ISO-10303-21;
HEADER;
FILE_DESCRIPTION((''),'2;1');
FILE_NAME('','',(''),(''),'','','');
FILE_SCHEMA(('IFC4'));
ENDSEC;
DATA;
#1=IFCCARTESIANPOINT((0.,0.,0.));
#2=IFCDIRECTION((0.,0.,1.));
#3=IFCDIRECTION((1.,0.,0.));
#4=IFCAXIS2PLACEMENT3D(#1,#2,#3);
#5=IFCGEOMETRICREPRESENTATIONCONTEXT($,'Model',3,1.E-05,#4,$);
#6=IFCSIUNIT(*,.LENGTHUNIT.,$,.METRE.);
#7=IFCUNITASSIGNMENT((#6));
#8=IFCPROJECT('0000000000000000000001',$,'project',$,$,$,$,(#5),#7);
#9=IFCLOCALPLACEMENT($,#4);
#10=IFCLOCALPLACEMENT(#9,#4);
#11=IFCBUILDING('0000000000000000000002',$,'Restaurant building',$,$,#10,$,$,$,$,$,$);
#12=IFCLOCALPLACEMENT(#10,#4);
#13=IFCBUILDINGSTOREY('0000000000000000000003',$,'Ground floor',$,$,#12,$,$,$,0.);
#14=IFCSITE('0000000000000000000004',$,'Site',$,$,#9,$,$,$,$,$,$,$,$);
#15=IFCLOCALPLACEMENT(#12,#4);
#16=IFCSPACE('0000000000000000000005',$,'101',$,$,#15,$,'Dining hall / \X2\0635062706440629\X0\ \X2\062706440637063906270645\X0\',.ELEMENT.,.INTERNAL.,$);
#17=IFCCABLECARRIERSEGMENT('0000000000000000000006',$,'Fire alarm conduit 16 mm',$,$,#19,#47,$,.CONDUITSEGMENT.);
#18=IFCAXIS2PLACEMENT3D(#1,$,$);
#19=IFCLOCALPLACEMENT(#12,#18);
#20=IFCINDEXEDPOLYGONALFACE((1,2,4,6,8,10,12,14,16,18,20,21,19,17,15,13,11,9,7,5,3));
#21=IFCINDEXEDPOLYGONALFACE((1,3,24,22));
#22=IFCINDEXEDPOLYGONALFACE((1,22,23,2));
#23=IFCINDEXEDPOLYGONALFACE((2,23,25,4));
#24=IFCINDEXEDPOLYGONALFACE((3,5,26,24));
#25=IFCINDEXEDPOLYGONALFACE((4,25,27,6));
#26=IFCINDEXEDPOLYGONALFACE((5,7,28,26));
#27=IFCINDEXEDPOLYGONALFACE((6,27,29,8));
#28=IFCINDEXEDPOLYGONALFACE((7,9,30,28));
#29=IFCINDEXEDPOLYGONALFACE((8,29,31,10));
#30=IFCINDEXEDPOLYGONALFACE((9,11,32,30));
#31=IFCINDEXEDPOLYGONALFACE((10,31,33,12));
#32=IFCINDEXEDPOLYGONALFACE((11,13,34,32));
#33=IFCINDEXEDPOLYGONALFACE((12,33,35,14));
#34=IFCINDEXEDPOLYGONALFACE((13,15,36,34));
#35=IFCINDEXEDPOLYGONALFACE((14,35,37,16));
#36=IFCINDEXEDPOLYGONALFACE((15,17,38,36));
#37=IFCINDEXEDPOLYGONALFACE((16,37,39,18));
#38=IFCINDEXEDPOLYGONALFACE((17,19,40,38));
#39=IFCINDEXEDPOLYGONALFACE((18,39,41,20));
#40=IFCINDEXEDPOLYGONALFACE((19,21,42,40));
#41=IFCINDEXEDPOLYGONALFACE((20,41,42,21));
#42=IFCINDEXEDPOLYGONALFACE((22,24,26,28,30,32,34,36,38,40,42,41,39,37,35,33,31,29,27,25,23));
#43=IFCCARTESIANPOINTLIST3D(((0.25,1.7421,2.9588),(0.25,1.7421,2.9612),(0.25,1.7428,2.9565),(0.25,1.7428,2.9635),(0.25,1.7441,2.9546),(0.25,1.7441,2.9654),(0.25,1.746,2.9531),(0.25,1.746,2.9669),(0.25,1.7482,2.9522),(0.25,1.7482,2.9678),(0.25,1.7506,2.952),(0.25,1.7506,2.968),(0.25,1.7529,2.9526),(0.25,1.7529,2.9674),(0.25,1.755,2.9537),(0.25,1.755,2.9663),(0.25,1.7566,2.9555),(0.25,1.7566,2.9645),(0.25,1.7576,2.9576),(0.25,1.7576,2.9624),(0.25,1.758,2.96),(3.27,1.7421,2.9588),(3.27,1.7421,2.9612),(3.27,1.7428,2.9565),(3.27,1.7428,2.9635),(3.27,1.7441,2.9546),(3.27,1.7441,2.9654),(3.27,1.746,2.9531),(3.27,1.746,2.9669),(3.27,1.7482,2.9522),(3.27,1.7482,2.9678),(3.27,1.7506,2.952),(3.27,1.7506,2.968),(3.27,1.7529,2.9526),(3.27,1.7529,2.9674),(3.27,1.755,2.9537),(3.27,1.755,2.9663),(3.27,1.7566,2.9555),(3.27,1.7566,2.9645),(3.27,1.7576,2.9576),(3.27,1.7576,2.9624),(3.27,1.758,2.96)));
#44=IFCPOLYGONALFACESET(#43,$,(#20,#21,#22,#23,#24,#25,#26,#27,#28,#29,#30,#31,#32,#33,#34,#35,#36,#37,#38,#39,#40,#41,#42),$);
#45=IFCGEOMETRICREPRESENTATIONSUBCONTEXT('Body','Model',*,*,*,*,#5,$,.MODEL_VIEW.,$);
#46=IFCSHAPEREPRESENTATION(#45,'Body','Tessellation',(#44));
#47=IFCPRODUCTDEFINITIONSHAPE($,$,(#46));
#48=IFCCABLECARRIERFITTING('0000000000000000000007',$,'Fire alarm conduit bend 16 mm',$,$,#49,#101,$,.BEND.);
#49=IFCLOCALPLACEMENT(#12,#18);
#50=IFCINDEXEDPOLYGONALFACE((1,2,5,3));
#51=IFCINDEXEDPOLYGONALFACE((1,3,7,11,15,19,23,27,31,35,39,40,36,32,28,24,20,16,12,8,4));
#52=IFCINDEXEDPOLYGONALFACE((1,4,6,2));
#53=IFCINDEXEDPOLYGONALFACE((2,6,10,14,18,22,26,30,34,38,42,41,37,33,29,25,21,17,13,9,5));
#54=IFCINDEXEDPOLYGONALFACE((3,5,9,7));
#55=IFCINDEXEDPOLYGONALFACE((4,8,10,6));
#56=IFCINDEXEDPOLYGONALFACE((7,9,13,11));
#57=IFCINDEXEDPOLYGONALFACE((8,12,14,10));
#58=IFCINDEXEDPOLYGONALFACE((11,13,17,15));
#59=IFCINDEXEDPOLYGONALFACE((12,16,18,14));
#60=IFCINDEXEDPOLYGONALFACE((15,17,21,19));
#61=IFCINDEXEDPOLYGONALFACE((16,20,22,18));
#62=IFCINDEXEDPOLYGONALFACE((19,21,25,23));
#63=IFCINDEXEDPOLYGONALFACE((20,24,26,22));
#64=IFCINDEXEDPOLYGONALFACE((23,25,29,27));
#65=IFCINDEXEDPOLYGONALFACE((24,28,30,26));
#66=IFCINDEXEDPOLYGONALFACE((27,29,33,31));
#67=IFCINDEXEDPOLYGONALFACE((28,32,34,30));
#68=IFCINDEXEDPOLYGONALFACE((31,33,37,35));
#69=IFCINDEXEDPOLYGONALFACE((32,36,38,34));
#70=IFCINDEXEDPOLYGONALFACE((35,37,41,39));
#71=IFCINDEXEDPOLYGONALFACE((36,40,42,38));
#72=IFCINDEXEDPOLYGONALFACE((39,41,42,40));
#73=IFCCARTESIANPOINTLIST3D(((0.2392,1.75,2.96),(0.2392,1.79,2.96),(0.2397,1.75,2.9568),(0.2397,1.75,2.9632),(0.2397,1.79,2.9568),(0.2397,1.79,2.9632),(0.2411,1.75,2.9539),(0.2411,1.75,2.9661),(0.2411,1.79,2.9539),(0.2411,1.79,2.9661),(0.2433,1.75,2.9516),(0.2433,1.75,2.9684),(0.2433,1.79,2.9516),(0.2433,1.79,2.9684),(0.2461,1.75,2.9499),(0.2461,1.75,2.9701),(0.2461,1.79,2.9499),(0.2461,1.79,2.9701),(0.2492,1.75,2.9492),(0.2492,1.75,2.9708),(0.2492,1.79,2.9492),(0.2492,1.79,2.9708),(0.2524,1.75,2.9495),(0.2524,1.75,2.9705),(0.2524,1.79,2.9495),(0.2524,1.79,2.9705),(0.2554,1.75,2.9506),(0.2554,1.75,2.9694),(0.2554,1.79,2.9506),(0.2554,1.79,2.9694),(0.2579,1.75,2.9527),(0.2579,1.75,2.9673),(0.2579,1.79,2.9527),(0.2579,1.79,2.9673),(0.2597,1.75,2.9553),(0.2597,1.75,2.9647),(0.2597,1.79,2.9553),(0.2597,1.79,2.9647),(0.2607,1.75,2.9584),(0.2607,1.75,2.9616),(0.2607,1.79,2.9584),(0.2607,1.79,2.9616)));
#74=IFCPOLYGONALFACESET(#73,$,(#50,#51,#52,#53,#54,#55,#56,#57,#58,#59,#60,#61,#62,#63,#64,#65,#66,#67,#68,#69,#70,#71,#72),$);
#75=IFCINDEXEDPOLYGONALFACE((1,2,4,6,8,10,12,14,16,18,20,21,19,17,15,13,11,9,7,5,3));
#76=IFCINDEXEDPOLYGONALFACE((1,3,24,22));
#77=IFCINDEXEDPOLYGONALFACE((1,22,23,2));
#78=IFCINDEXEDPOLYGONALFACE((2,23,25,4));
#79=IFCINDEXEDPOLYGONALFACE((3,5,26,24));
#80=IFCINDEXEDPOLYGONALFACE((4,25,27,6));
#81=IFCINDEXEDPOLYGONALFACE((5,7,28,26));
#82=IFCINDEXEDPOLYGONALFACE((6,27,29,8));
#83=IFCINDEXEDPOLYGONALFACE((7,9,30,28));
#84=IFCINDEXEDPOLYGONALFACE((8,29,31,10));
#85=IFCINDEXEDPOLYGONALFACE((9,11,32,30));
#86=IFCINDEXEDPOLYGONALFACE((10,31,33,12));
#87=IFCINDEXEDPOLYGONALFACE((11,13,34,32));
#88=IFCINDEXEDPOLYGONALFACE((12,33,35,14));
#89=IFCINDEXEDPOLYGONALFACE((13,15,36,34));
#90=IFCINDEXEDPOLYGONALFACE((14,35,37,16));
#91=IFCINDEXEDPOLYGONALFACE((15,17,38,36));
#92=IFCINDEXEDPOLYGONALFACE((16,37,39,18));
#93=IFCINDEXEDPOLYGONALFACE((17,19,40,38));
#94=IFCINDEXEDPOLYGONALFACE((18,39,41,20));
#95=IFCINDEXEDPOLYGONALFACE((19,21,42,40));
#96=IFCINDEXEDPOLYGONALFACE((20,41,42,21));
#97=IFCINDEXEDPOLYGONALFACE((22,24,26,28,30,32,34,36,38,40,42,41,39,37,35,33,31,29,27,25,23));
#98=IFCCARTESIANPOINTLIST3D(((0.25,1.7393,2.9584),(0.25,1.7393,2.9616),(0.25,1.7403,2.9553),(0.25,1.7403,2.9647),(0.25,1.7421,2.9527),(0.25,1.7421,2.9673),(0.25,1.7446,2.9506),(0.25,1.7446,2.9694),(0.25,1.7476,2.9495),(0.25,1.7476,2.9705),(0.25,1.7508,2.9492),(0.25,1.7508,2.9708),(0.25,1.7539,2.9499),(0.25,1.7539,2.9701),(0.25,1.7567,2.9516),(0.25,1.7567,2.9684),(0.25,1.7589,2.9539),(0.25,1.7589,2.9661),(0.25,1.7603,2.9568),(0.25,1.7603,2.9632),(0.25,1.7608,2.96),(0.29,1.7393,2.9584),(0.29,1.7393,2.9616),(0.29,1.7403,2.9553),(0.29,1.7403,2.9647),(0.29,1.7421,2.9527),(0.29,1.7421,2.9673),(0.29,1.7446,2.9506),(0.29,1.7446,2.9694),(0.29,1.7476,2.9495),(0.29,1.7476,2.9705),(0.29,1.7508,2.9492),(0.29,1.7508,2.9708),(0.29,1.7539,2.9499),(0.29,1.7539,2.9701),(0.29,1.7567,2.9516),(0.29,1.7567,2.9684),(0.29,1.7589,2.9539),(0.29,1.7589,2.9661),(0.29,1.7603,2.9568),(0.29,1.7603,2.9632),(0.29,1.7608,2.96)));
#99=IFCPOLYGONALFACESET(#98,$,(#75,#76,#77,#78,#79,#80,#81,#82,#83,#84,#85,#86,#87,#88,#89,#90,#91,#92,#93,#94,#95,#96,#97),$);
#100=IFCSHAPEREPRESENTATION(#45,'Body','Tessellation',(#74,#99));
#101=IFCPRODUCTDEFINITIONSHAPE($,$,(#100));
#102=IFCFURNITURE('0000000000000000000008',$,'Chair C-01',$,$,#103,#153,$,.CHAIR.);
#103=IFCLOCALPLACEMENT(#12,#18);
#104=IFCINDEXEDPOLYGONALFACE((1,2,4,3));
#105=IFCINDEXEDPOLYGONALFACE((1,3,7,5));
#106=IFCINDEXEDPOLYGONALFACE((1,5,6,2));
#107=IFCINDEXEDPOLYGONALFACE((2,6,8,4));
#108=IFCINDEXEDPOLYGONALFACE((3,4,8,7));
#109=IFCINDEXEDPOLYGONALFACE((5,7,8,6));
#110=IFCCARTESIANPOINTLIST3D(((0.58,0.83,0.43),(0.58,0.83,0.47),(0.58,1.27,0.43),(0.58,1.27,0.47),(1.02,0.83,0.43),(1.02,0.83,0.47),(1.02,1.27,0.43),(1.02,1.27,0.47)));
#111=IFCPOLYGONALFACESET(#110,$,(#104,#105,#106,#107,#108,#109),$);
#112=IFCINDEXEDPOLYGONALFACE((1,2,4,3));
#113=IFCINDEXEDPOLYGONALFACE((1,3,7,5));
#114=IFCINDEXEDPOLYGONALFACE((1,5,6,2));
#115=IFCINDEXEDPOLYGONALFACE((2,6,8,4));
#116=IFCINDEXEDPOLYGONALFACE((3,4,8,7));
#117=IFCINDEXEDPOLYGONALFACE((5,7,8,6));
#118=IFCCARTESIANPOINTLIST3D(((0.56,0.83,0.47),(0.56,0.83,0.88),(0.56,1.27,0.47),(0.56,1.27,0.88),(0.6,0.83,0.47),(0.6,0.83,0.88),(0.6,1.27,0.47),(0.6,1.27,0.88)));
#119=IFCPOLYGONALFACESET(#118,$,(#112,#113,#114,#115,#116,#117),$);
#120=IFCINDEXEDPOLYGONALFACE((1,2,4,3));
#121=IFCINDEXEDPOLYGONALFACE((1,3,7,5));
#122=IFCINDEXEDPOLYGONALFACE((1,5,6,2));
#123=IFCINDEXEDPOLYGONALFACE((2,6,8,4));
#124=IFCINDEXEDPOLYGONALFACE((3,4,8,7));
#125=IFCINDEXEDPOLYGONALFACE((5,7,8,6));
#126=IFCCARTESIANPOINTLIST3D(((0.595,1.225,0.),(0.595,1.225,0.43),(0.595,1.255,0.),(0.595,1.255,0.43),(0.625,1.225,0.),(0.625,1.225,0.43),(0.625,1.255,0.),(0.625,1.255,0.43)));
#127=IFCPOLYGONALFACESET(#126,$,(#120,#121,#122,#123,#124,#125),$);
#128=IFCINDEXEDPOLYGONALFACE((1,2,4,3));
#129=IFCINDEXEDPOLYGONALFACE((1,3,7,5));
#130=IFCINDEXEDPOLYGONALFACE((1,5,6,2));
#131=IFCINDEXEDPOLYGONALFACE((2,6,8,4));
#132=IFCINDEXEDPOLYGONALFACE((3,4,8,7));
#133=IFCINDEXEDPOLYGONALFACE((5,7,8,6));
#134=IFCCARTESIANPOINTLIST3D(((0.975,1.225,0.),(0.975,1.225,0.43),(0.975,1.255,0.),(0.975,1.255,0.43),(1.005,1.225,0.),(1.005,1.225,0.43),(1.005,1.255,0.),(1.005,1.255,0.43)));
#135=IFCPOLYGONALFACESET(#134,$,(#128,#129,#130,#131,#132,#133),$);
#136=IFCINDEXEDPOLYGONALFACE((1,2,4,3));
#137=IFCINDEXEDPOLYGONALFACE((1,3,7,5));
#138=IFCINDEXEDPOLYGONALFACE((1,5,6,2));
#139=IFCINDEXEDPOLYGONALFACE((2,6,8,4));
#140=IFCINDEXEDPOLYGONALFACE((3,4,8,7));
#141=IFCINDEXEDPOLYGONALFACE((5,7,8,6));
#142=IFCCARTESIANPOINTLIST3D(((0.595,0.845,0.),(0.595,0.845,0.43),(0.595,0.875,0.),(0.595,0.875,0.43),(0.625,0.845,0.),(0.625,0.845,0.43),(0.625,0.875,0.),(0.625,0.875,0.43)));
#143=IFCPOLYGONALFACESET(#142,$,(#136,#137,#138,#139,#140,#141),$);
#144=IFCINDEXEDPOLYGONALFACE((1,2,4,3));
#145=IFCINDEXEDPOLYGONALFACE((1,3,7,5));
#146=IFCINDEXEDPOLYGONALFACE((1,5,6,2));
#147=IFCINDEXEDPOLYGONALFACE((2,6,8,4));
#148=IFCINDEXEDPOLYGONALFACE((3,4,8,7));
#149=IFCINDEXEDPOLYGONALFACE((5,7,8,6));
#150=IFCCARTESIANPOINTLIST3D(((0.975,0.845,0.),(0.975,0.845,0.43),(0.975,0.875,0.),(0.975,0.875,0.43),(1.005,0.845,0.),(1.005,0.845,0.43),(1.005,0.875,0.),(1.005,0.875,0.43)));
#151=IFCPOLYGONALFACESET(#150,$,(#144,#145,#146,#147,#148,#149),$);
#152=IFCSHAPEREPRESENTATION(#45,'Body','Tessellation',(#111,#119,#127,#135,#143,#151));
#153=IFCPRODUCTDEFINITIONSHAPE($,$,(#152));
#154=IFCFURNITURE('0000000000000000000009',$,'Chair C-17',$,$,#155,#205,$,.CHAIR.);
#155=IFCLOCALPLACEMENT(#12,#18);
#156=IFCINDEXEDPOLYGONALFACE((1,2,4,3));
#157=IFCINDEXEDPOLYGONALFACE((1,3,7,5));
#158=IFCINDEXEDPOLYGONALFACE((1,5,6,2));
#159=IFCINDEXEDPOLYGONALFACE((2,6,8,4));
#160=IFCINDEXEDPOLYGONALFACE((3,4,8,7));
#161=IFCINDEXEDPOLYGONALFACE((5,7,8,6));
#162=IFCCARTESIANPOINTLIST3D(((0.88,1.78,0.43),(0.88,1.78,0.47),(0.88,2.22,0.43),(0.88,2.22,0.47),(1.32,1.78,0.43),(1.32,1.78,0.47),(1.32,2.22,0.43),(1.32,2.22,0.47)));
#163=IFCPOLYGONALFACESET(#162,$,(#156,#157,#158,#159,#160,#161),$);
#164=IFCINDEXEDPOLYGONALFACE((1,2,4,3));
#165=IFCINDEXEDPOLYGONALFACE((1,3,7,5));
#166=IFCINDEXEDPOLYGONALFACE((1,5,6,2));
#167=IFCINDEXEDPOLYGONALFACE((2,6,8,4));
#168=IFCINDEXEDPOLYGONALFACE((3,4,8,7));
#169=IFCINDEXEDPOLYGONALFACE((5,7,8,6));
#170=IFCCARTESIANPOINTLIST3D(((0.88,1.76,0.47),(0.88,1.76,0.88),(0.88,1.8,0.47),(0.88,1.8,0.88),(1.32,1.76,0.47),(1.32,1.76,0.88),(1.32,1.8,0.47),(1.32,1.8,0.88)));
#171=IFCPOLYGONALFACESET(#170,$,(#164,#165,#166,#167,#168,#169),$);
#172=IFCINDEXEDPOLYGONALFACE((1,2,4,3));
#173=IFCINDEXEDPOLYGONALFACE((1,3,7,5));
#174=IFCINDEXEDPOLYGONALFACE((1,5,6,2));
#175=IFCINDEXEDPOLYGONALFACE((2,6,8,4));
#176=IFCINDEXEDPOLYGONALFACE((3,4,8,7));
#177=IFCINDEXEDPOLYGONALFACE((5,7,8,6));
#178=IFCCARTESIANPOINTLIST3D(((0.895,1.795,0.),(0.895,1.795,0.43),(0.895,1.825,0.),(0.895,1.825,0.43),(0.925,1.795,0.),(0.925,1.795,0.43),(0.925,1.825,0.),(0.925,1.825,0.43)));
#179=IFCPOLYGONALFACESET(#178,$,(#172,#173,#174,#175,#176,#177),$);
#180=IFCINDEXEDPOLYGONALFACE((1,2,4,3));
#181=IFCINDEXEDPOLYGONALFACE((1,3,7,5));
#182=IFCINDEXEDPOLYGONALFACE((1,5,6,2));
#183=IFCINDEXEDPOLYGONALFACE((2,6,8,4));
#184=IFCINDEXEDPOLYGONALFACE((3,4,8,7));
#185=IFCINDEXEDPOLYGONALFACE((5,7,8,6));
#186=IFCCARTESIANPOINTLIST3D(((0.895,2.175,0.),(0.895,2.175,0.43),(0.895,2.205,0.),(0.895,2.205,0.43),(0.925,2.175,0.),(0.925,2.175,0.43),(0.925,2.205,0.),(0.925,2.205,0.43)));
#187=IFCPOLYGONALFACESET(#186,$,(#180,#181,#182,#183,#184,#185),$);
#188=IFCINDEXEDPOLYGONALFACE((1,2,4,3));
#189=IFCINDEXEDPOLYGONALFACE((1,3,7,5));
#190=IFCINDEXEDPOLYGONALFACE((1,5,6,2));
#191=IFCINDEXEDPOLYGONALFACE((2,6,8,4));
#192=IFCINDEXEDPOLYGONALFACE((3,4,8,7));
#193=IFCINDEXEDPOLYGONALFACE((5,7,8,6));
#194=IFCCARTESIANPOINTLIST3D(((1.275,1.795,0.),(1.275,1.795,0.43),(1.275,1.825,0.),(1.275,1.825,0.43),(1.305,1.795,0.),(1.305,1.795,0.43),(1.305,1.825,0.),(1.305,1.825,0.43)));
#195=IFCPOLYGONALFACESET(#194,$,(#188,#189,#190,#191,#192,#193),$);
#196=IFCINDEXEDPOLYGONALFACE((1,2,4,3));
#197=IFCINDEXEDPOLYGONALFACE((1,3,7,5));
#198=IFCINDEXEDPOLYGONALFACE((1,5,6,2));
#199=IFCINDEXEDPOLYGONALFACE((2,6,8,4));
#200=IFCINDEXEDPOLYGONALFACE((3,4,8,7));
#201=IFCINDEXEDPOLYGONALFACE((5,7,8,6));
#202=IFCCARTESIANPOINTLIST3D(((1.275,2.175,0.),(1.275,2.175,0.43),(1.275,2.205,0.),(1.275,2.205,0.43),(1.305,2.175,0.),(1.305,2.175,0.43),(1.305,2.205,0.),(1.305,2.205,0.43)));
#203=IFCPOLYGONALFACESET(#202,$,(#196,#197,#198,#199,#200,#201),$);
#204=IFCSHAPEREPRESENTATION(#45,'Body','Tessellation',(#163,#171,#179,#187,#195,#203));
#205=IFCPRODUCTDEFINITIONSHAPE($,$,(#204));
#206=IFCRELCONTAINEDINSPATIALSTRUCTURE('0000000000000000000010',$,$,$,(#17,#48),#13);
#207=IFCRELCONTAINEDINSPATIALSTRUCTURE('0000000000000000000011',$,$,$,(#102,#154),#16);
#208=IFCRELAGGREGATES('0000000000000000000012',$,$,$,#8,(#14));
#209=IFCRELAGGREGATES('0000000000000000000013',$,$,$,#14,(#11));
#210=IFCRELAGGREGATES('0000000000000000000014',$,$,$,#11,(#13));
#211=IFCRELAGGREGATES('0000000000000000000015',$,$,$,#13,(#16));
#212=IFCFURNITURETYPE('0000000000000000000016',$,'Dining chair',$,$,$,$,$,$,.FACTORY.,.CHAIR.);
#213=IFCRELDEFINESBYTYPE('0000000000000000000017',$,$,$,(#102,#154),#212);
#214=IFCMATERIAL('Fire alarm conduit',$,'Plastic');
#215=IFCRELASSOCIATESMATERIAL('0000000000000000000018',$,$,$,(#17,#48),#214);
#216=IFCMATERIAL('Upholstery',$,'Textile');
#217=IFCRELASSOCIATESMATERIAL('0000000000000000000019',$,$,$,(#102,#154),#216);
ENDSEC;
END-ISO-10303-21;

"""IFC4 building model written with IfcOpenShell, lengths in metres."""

from ifc_helpers import new_model, si_unit, frame, origin, origin_with_axes, origin_2d, place, context, subcontext, project, spatial, rectangle, circle, extrude, source, transform, mapped, material, type_object, type_shapes, element, save


model = new_model("IFC4")

# Units and contexts
model_context = context("Model", 3, precision=1e-05, world=origin_with_axes())
body_context = subcontext(model_context, "Body", "Model", "MODEL_VIEW")
ifc_project = project(units=[si_unit("LENGTHUNIT", "METRE")], contexts=[model_context])

# Site, building, storey
site_placement = place(None, origin_with_axes())
site = spatial("IfcSite", under=ifc_project, at=site_placement, Name="Site")
building_placement = place(site_placement, origin_with_axes())
building = spatial("IfcBuilding", under=site, at=building_placement, Name="Restaurant building")
storey_placement = place(building_placement, origin_with_axes())
storey = spatial("IfcBuildingStorey", under=building, at=storey_placement, Name="Ground floor", Elevation=0.0)

# Shared definitions
space_1_placement = place(storey_placement, origin_with_axes())
space_1 = spatial("IfcSpace", under=storey, at=space_1_placement, Name="101", LongName="Dining hall / صالة الطعام", CompositionType="ELEMENT", PredefinedType="INTERNAL")

# Cable carrier segment
ifc_material_1 = material(Name="Fire alarm conduit", Category="Plastic")
cable_carrier_segment_1_placement = place(storey_placement, frame((0.25, 1.75, 2.96)))
element("IfcCableCarrierSegment", 1, at=cable_carrier_segment_1_placement, inside=storey, material=ifc_material_1, Name="Fire alarm conduit 16 mm", PredefinedType="CONDUITSEGMENT", context=body_context, shape_type="SweptSolid", body=[
    extrude(circle(Radius=0.008, at=origin_2d()), frame((0.0, 0.0, 0.0), z_axis=(1.0, 0.0, 0.0), x_axis=(0.0, 1.0, 0.0)), (0.0, 0.0, 1.0), 3.02),
])

# Cable carrier fitting
cable_carrier_fitting_placement = place(storey_placement, frame((0.25, 1.75, 2.96)))
element("IfcCableCarrierFitting", 2, at=cable_carrier_fitting_placement, inside=storey, material=ifc_material_1, Name="Fire alarm conduit bend 16 mm", PredefinedType="BEND", context=body_context, shape_type="SweptSolid", body=[
    extrude(circle(Radius=0.0108, at=origin_2d()), frame((0.0, 0.0, 0.0), z_axis=(0.0, 1.0, 0.0), x_axis=(-1.0, 0.0, 0.0)), (0.0, 0.0, 1.0), 0.04),
    extrude(circle(Radius=0.0108, at=origin_2d()), frame((0.0, 0.0, 0.0), z_axis=(1.0, 0.0, 0.0), x_axis=(0.0, 1.0, 0.0)), (0.0, 0.0, 1.0), 0.04),
])

# Furniture
ifc_material_2 = material(Name="Upholstery", Category="Textile")
furniture_type_1 = type_object("IfcFurnitureType", Name="Dining chair", AssemblyPlace="FACTORY", PredefinedType="CHAIR")
shared_shape_1 = source(origin(), body_context, "Body", "SweptSolid", [
    extrude(rectangle(XDim=0.44, YDim=0.44, at=origin_2d()), frame((0.0, 0.0, 0.43)), (0.0, 0.0, 1.0), 0.04),
    extrude(rectangle(XDim=0.44, YDim=0.04, at=origin_2d()), frame((0.0, -0.22, 0.47)), (0.0, 0.0, 1.0), 0.41),
    extrude(rectangle(XDim=0.03, YDim=0.03, at=origin_2d()), frame((-0.19, -0.19, 0.0)), (0.0, 0.0, 1.0), 0.43),
    extrude(rectangle(XDim=0.03, YDim=0.03, at=origin_2d()), frame((-0.19, 0.19, 0.0)), (0.0, 0.0, 1.0), 0.43),
    extrude(rectangle(XDim=0.03, YDim=0.03, at=origin_2d()), frame((0.19, -0.19, 0.0)), (0.0, 0.0, 1.0), 0.43),
    extrude(rectangle(XDim=0.03, YDim=0.03, at=origin_2d()), frame((0.19, 0.19, 0.0)), (0.0, 0.0, 1.0), 0.43),
])
type_shapes(furniture_type_1, [shared_shape_1])
furniture_1_placement = place(storey_placement, frame((0.8, 1.05, 0.0), z_axis=(0.0, 0.0, 1.0), x_axis=(0.0, -1.0, 0.0)))
element("IfcFurniture", 3, at=furniture_1_placement, inside=space_1, type_object=furniture_type_1, material=ifc_material_2, Name="Chair C-01", PredefinedType="CHAIR", context=body_context, shape_type="MappedRepresentation", body=[
    mapped(shared_shape_1, transform((0.0, 0.0, 0.0))),
])
for number, where, name in (
    (4, (1.1, 2.0, 0.0), "Chair C-17"),
):
    element("IfcFurniture", number, at=place(storey_placement, frame(where)), inside=space_1, type_object=furniture_type_1, material=ifc_material_2, Name=name, PredefinedType="CHAIR", context=body_context, shape_type="MappedRepresentation", body=[
        mapped(shared_shape_1, transform((0.0, 0.0, 0.0))),
    ])

save(model, "model.ifc")
